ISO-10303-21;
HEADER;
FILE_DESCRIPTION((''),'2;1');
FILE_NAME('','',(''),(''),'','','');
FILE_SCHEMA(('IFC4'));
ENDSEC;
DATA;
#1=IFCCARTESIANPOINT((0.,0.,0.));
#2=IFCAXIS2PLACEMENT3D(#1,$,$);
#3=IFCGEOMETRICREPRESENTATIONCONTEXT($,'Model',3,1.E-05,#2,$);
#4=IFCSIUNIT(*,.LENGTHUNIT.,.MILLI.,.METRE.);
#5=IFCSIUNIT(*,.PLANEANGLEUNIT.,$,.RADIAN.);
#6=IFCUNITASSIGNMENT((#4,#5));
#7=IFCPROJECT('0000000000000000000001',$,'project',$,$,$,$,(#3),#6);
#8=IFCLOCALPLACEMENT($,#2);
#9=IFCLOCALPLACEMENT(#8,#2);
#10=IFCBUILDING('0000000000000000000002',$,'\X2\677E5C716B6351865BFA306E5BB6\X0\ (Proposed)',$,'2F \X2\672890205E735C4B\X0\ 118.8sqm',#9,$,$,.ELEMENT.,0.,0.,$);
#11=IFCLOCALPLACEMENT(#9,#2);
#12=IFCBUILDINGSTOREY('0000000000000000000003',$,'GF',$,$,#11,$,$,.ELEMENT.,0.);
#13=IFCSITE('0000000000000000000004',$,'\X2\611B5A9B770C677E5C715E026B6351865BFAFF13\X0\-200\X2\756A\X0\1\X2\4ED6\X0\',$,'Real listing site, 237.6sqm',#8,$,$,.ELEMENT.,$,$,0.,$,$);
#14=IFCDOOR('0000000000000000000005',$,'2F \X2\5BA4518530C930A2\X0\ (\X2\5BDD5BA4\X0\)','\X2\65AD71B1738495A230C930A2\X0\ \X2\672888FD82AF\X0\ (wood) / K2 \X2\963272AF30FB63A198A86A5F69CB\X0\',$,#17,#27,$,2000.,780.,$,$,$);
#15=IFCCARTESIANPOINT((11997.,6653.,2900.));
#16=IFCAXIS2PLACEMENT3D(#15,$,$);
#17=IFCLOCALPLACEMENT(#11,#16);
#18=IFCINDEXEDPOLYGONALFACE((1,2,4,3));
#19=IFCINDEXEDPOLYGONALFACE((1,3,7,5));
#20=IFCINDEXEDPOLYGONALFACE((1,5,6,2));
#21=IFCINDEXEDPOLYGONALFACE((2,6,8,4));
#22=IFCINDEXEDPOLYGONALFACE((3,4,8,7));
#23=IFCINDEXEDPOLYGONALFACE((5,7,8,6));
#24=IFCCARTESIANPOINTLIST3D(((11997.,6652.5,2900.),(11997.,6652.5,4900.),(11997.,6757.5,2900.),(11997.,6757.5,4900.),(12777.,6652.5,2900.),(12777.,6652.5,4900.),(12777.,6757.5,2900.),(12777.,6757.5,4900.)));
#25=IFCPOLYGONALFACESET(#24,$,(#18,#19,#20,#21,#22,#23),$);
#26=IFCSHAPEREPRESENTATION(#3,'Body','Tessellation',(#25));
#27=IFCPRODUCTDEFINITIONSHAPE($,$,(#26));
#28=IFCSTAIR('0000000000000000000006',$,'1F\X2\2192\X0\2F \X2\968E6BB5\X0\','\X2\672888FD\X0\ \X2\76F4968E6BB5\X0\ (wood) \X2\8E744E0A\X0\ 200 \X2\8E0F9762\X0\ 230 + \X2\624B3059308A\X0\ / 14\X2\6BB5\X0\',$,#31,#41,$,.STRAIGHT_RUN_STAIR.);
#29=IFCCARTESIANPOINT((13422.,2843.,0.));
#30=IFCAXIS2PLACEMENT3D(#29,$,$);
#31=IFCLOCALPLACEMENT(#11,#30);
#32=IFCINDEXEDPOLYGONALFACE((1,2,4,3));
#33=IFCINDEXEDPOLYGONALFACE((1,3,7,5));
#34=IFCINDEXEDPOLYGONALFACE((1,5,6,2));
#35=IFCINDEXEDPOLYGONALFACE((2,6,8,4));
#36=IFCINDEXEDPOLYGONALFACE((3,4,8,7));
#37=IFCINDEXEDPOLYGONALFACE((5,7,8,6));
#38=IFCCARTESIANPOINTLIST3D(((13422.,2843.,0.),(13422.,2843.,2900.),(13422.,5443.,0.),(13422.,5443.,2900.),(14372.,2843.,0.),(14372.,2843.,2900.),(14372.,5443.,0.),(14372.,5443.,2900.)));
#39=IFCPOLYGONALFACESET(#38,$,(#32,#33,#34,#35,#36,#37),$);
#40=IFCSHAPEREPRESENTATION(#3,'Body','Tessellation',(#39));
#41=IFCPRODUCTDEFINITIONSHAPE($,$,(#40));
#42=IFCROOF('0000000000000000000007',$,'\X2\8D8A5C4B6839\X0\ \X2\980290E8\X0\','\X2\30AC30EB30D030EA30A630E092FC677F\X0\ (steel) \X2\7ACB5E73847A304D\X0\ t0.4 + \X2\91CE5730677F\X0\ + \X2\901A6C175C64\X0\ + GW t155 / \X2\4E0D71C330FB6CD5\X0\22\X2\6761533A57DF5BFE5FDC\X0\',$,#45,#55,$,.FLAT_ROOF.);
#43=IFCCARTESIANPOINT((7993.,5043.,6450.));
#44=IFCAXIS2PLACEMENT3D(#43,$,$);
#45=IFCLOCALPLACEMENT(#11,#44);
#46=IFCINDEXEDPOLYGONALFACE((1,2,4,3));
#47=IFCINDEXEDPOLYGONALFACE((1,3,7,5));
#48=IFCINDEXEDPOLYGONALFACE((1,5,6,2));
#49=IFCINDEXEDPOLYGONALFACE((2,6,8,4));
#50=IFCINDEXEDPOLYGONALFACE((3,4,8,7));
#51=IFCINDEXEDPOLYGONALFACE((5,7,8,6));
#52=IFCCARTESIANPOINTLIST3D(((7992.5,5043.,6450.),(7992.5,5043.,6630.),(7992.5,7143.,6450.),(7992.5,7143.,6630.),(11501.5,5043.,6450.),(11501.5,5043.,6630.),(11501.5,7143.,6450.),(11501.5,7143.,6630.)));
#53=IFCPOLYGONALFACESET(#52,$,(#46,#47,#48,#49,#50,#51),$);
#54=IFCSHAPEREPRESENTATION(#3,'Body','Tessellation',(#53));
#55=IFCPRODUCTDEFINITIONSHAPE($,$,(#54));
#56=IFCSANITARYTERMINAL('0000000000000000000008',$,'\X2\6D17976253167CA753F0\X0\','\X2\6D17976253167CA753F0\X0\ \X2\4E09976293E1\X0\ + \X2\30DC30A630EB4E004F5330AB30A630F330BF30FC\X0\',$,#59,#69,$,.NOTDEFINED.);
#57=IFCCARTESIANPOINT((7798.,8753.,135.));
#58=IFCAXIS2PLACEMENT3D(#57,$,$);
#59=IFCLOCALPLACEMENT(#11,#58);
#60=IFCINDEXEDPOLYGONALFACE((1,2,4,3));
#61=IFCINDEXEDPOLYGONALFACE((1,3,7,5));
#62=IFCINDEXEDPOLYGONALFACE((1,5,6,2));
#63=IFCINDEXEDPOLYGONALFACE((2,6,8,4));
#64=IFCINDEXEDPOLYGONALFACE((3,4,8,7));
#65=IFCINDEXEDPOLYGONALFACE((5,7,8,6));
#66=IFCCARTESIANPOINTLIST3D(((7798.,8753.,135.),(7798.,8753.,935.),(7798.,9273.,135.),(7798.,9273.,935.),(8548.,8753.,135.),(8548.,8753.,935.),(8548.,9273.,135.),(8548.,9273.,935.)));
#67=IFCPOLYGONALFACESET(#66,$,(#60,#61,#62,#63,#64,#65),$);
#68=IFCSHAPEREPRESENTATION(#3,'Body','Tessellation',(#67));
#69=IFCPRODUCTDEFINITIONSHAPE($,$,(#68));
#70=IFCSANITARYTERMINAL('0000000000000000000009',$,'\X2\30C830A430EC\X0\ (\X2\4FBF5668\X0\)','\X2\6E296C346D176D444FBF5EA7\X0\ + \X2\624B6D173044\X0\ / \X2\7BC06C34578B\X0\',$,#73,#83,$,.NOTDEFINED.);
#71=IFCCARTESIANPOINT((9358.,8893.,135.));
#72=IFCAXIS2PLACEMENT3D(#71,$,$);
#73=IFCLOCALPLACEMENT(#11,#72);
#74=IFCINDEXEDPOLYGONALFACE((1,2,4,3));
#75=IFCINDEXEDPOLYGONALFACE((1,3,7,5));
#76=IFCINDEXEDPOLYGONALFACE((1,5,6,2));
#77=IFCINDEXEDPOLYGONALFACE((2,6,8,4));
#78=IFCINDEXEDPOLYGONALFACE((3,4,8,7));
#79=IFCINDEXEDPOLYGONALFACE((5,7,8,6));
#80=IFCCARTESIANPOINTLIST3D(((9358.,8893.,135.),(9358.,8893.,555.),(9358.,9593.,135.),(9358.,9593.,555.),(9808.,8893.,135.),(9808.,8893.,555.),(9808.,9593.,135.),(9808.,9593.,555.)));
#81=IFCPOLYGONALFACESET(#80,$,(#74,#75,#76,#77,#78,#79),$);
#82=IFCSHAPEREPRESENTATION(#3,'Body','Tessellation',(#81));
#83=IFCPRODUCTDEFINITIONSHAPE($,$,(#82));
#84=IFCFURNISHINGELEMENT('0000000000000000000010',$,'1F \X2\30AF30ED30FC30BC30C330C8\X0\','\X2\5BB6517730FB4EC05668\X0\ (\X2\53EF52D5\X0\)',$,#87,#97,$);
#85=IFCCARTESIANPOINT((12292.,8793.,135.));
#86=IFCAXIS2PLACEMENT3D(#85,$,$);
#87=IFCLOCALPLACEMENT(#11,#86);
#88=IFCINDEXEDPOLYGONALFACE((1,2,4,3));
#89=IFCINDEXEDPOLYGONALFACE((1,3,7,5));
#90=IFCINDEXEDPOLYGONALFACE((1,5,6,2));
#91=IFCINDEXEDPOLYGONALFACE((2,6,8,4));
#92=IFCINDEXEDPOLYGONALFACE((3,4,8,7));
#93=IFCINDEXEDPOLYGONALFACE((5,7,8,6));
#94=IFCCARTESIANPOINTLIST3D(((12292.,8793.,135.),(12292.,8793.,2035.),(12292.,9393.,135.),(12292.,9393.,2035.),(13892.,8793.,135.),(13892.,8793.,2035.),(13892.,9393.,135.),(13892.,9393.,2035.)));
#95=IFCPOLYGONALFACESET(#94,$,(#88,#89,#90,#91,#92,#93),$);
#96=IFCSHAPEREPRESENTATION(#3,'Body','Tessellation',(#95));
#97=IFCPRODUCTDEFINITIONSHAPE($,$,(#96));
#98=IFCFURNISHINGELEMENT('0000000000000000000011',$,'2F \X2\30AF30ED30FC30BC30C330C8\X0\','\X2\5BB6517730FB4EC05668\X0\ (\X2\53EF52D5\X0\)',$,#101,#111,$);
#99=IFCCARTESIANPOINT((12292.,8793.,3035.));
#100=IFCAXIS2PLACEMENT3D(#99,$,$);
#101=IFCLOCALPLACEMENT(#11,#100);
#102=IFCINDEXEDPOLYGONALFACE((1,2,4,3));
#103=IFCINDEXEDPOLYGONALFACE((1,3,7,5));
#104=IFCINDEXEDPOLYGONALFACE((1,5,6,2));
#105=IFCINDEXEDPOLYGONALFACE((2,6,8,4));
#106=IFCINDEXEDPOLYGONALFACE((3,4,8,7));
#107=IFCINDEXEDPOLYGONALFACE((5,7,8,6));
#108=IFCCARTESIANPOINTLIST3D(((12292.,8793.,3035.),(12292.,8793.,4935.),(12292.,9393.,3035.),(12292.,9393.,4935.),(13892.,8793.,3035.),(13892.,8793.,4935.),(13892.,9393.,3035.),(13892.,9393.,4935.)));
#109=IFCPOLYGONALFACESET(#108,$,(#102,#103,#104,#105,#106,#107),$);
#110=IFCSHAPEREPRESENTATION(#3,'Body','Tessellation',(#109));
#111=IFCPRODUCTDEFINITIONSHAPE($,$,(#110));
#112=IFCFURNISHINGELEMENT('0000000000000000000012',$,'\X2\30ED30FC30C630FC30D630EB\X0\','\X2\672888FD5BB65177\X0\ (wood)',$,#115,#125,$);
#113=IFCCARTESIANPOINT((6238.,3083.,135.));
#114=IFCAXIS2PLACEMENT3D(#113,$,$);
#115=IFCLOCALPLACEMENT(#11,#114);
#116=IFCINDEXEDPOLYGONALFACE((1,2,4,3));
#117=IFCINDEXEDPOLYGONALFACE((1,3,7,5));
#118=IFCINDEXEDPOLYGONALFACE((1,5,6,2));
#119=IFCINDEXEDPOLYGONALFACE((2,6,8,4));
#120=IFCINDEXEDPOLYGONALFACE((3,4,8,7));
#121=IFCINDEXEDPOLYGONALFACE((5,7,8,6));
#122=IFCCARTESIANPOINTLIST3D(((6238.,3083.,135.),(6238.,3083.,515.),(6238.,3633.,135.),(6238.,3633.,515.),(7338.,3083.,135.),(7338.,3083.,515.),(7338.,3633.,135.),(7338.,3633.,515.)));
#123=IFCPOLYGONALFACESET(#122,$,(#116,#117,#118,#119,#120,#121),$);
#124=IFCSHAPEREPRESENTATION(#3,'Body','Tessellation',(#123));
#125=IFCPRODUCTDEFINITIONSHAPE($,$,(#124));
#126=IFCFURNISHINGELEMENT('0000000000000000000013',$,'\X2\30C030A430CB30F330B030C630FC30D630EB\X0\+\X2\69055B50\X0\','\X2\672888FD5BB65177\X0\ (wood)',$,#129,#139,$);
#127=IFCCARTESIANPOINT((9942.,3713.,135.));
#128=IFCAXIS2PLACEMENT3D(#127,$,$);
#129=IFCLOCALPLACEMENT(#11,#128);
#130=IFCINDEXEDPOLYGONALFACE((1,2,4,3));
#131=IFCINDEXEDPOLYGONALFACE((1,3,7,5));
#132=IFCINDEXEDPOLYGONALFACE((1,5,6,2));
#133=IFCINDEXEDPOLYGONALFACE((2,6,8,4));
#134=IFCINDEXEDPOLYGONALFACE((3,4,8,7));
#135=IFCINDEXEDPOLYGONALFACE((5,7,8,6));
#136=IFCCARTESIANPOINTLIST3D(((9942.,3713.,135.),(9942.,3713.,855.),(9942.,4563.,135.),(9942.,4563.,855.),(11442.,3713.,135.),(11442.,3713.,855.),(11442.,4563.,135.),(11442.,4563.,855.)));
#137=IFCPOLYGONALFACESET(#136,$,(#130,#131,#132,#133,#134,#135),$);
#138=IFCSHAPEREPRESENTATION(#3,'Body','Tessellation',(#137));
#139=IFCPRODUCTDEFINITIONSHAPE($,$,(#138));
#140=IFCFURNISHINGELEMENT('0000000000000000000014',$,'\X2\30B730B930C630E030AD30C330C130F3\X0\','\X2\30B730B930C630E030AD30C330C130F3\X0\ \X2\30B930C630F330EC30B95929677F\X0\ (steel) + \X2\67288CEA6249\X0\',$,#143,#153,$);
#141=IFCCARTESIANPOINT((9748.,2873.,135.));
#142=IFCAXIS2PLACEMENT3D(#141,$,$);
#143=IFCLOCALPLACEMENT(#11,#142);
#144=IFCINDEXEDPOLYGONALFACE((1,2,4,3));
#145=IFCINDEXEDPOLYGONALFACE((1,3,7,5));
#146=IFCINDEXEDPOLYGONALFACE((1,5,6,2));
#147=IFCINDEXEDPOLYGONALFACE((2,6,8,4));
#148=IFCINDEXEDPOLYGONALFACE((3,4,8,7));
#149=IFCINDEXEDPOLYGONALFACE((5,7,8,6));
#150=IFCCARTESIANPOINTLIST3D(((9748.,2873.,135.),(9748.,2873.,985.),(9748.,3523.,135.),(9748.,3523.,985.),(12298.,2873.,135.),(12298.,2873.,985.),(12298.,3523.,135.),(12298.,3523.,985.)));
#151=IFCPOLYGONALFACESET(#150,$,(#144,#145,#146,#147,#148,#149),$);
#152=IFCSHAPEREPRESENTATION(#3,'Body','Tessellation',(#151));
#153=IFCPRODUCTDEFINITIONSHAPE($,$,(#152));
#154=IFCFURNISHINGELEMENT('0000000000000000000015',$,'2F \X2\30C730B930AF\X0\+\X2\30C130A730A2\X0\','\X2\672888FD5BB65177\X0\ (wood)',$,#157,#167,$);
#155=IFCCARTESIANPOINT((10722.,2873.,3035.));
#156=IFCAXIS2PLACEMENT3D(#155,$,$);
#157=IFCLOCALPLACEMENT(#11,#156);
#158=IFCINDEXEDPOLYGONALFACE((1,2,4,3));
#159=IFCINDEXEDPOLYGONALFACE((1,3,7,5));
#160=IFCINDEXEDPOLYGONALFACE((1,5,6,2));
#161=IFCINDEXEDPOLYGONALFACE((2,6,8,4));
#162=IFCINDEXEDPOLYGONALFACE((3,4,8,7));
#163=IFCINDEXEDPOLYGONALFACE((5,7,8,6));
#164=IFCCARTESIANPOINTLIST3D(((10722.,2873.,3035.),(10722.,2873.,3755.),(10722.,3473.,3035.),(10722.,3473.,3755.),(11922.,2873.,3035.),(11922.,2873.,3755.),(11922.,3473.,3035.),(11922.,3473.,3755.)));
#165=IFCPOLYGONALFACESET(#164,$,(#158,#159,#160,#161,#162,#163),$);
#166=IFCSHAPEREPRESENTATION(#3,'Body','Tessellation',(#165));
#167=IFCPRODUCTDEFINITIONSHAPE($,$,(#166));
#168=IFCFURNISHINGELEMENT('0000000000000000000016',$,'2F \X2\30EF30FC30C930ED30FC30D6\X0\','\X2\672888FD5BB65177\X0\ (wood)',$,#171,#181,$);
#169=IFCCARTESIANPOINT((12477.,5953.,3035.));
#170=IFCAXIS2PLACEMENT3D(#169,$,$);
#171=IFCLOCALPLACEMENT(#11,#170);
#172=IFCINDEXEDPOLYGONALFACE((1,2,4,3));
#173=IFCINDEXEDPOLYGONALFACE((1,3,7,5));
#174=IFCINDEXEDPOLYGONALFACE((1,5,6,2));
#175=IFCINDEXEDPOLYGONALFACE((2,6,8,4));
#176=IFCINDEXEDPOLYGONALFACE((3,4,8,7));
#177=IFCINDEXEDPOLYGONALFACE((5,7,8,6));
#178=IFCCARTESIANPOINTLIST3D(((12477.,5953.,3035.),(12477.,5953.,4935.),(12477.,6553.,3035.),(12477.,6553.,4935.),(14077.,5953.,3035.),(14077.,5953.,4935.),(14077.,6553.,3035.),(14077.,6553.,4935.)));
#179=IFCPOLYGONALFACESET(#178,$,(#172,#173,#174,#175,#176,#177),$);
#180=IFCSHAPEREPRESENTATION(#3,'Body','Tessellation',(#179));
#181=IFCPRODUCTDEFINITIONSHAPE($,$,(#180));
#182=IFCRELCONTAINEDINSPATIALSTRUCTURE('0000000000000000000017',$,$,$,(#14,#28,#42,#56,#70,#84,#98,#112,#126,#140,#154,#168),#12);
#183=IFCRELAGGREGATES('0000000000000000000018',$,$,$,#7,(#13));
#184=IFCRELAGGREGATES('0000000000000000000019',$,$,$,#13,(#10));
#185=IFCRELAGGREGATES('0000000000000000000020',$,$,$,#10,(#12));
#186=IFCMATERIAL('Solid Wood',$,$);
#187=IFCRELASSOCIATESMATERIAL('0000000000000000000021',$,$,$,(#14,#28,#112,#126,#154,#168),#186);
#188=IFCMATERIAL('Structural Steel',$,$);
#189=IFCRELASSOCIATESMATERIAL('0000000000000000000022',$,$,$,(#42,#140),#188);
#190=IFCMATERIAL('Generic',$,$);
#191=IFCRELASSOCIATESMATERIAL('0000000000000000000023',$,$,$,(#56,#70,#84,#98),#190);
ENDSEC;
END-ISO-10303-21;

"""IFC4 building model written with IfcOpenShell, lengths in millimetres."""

from ifc_helpers import new_model, si_unit, frame, frame_2d, origin, place, context, project, spatial, rectangle, extrude, material, element, save


model = new_model("IFC4")

# Units and contexts
model_context = context("Model", 3, precision=1e-05, world=origin())
ifc_project = project(units=[si_unit("LENGTHUNIT", "METRE", prefix="MILLI"), si_unit("PLANEANGLEUNIT", "RADIAN")], contexts=[model_context])

# Site, building, storey
site_placement = place(None, origin())
site = spatial("IfcSite", under=ifc_project, at=site_placement, Name="愛媛県松山市正円寺３-200番1他", ObjectType="Real listing site, 237.6sqm", CompositionType="ELEMENT", RefElevation=0.0)
building_placement = place(site_placement, origin())
building = spatial("IfcBuilding", under=site, at=building_placement, Name="松山正円寺の家 (Proposed)", ObjectType="2F 木造平屋 118.8sqm", CompositionType="ELEMENT", ElevationOfRefHeight=0.0, ElevationOfTerrain=0.0)
storey_placement = place(building_placement, origin())
storey = spatial("IfcBuildingStorey", under=building, at=storey_placement, Name="GF", CompositionType="ELEMENT", Elevation=0.0)

# Shared definitions
ifc_material_1 = material(Name="Solid Wood")

# Door
door_1_placement = place(storey_placement, frame((11997.0, 6653.0, 2900.0)))
element("IfcDoor", 1, at=door_1_placement, inside=storey, material=ifc_material_1, Name="2F 室内ドア (寝室)", Description="断熱玄関ドア 木製芯 (wood) / K2 防犯・採風機構", OverallHeight=2000.0, OverallWidth=780.0, context=model_context, shape_type="SweptSolid", body=[
    extrude(rectangle(XDim=780.0, YDim=105.0, at=frame_2d((390.0, 52.0))), frame((11997.0, 6653.0, 2900.0)), (0.0, 0.0, 1.0), 2000.0),
])

# Stair
stair_placement = place(storey_placement, frame((13422.0, 2843.0, 0.0)))
element("IfcStair", 2, at=stair_placement, inside=storey, material=ifc_material_1, Name="1F→2F 階段", Description="木製 直階段 (wood) 蹴上 200 踏面 230 + 手すり / 14段", PredefinedType="STRAIGHT_RUN_STAIR", context=model_context, shape_type="SweptSolid", body=[
    extrude(rectangle(XDim=950.0, YDim=2600.0, at=frame_2d((475.0, 1300.0))), frame((13422.0, 2843.0, 0.0)), (0.0, 0.0, 1.0), 2900.0),
])

# Roof
ifc_material_2 = material(Name="Structural Steel")
roof_placement = place(storey_placement, frame((7993.0, 5043.0, 6450.0)))
element("IfcRoof", 3, at=roof_placement, inside=storey, material=ifc_material_2, Name="越屋根 頂部", Description="ガルバリウム鋼板 (steel) 立平葺き t0.4 + 野地板 + 通気層 + GW t155 / 不燃・法22条区域対応", PredefinedType="FLAT_ROOF", context=model_context, shape_type="SweptSolid", body=[
    extrude(rectangle(XDim=3509.0, YDim=2100.0, at=frame_2d((1754.0, 1050.0))), frame((7993.0, 5043.0, 6450.0)), (0.0, 0.0, 1.0), 180.0),
])

# Sanitary terminals
ifc_material_3 = material(Name="Generic")
sanitary_terminal_1_placement = place(storey_placement, frame((7798.0, 8753.0, 135.0)))
element("IfcSanitaryTerminal", 4, at=sanitary_terminal_1_placement, inside=storey, material=ifc_material_3, Name="洗面化粧台", Description="洗面化粧台 三面鏡 + ボウル一体カウンター", PredefinedType="NOTDEFINED", context=model_context, shape_type="SweptSolid", body=[
    extrude(rectangle(XDim=750.0, YDim=520.0, at=frame_2d((375.0, 260.0))), frame((7798.0, 8753.0, 135.0)), (0.0, 0.0, 1.0), 800.0),
])
sanitary_terminal_2_placement = place(storey_placement, frame((9358.0, 8893.0, 135.0)))
element("IfcSanitaryTerminal", 5, at=sanitary_terminal_2_placement, inside=storey, material=ifc_material_3, Name="トイレ (便器)", Description="温水洗浄便座 + 手洗い / 節水型", PredefinedType="NOTDEFINED", context=model_context, shape_type="SweptSolid", body=[
    extrude(rectangle(XDim=450.0, YDim=700.0, at=frame_2d((225.0, 350.0))), frame((9358.0, 8893.0, 135.0)), (0.0, 0.0, 1.0), 420.0),
])

# Furnishing elements
furnishing_1_placement = place(storey_placement, frame((12292.0, 8793.0, 135.0)))
element("IfcFurnishingElement", 6, at=furnishing_1_placement, inside=storey, material=ifc_material_3, Name="1F クローゼット", Description="家具・什器 (可動)", context=model_context, shape_type="SweptSolid", body=[
    extrude(rectangle(XDim=1600.0, YDim=600.0, at=frame_2d((800.0, 300.0))), frame((12292.0, 8793.0, 135.0)), (0.0, 0.0, 1.0), 1900.0),
])
furnishing_2_placement = place(storey_placement, frame((12292.0, 8793.0, 3035.0)))
element("IfcFurnishingElement", 7, at=furnishing_2_placement, inside=storey, material=ifc_material_3, Name="2F クローゼット", Description="家具・什器 (可動)", context=model_context, shape_type="SweptSolid", body=[
    extrude(rectangle(XDim=1600.0, YDim=600.0, at=frame_2d((800.0, 300.0))), frame((12292.0, 8793.0, 3035.0)), (0.0, 0.0, 1.0), 1900.0),
])
furnishing_3_placement = place(storey_placement, frame((6238.0, 3083.0, 135.0)))
element("IfcFurnishingElement", 8, at=furnishing_3_placement, inside=storey, material=ifc_material_1, Name="ローテーブル", Description="木製家具 (wood)", context=model_context, shape_type="SweptSolid", body=[
    extrude(rectangle(XDim=1100.0, YDim=550.0, at=frame_2d((550.0, 275.0))), frame((6238.0, 3083.0, 135.0)), (0.0, 0.0, 1.0), 380.0),
])
furnishing_4_placement = place(storey_placement, frame((9942.0, 3713.0, 135.0)))
element("IfcFurnishingElement", 9, at=furnishing_4_placement, inside=storey, material=ifc_material_1, Name="ダイニングテーブル+椅子", Description="木製家具 (wood)", context=model_context, shape_type="SweptSolid", body=[
    extrude(rectangle(XDim=1500.0, YDim=850.0, at=frame_2d((750.0, 425.0))), frame((9942.0, 3713.0, 135.0)), (0.0, 0.0, 1.0), 720.0),
])
furnishing_5_placement = place(storey_placement, frame((9748.0, 2873.0, 135.0)))
element("IfcFurnishingElement", 10, at=furnishing_5_placement, inside=storey, material=ifc_material_2, Name="システムキッチン", Description="システムキッチン ステンレス天板 (steel) + 木質扉", context=model_context, shape_type="SweptSolid", body=[
    extrude(rectangle(XDim=2550.0, YDim=650.0, at=frame_2d((1275.0, 325.0))), frame((9748.0, 2873.0, 135.0)), (0.0, 0.0, 1.0), 850.0),
])
furnishing_6_placement = place(storey_placement, frame((10722.0, 2873.0, 3035.0)))
element("IfcFurnishingElement", 11, at=furnishing_6_placement, inside=storey, material=ifc_material_1, Name="2F デスク+チェア", Description="木製家具 (wood)", context=model_context, shape_type="SweptSolid", body=[
    extrude(rectangle(XDim=1200.0, YDim=600.0, at=frame_2d((600.0, 300.0))), frame((10722.0, 2873.0, 3035.0)), (0.0, 0.0, 1.0), 720.0),
])
furnishing_7_placement = place(storey_placement, frame((12477.0, 5953.0, 3035.0)))
element("IfcFurnishingElement", 12, at=furnishing_7_placement, inside=storey, material=ifc_material_1, Name="2F ワードローブ", Description="木製家具 (wood)", context=model_context, shape_type="SweptSolid", body=[
    extrude(rectangle(XDim=1600.0, YDim=600.0, at=frame_2d((800.0, 300.0))), frame((12477.0, 5953.0, 3035.0)), (0.0, 0.0, 1.0), 1900.0),
])

save(model, "model.ifc")
